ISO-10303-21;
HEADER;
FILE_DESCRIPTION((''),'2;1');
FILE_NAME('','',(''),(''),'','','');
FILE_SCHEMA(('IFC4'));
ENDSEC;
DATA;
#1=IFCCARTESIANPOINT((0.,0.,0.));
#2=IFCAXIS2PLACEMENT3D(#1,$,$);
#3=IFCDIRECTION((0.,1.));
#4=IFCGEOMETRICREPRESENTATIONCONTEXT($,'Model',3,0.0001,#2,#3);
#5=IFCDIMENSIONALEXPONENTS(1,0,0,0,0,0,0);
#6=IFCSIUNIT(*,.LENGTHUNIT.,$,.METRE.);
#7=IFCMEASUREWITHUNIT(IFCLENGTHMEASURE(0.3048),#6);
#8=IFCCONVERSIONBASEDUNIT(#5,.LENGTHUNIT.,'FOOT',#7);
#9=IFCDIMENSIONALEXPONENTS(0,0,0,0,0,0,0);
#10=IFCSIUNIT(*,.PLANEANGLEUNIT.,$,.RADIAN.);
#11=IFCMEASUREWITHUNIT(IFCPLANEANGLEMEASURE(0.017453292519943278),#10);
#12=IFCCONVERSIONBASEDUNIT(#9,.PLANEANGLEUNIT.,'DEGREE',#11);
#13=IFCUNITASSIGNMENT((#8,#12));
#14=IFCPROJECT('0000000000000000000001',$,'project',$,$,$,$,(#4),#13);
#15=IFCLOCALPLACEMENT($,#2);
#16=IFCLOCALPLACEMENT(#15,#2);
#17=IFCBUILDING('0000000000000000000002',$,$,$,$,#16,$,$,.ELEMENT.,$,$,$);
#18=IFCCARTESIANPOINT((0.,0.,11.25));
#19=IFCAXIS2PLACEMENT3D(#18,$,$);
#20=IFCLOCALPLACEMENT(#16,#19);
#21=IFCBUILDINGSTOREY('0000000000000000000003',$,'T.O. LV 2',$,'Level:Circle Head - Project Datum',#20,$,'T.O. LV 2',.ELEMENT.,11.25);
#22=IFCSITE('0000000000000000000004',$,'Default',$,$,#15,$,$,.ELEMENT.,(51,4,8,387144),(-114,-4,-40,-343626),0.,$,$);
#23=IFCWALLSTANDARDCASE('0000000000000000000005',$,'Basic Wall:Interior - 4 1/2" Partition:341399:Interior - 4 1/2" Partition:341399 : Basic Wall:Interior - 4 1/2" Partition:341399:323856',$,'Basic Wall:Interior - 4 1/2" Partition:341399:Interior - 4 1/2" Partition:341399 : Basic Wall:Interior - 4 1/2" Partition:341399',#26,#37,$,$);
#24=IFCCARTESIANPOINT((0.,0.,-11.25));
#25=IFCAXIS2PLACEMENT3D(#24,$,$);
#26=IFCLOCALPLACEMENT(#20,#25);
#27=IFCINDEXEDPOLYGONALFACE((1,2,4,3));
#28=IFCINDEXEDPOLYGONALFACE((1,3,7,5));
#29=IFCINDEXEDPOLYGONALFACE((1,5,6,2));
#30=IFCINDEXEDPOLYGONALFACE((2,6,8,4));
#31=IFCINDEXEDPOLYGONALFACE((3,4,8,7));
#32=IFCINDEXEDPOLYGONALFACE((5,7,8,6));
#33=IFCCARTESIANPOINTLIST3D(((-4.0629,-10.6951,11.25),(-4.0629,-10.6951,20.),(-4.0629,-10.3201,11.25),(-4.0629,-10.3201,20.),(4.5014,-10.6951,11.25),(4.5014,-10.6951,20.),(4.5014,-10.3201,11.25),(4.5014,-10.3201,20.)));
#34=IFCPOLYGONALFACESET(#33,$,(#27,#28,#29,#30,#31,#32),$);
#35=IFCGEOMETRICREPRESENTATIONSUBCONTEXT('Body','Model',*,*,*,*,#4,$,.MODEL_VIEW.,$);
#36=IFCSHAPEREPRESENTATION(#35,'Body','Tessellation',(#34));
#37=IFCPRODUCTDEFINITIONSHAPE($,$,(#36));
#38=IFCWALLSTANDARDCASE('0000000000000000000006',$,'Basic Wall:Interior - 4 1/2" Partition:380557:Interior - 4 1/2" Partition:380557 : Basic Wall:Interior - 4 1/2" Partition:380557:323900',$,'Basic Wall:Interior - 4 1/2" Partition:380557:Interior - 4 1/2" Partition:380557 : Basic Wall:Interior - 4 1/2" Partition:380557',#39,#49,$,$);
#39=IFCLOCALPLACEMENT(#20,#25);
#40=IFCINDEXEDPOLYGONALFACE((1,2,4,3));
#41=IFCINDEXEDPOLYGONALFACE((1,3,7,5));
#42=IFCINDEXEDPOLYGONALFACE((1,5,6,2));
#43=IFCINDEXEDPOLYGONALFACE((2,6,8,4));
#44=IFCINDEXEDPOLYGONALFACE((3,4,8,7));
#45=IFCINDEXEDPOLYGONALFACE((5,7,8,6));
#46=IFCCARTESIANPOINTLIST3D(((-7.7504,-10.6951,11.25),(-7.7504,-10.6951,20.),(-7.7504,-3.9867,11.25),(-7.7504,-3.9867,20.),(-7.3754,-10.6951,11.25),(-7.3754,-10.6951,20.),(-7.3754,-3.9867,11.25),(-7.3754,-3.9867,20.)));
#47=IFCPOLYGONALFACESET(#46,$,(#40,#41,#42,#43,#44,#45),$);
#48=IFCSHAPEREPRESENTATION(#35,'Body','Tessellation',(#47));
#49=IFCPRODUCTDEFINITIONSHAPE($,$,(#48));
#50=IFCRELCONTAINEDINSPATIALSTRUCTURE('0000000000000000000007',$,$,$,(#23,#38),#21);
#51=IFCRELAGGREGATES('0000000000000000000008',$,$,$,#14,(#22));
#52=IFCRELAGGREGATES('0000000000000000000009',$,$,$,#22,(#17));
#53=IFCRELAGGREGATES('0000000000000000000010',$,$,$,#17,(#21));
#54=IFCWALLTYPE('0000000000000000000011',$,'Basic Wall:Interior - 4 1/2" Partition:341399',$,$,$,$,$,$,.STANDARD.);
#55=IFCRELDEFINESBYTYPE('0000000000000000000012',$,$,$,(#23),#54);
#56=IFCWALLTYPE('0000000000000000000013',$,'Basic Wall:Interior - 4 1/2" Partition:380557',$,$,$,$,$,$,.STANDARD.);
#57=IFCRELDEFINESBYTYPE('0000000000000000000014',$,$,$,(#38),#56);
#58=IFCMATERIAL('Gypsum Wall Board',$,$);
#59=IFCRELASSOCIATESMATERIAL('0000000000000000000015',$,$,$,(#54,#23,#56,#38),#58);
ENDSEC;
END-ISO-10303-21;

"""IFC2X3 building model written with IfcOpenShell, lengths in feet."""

from ifc_helpers import new_model, entity, si_unit, converted_unit, direction, frame, origin, origin_2d_with_axis, place, context, subcontext, project, spatial, rectangle, extrude, source, transform, mapped, material, type_object, type_shapes, element, save


model = new_model("IFC2X3")

# Units and contexts
model_context = context("Model", 3, precision=0.0001, world=origin(), true_north=direction((0.0, 1.0)))
body_context = subcontext(model_context, "Body", "Model", "MODEL_VIEW")
ifc_project = project(units=[converted_unit("LENGTHUNIT", "FOOT", entity("IfcLengthMeasure", 0.3048), si_unit("LENGTHUNIT", "METRE"), dimensions=[1, 0, 0, 0, 0, 0, 0]), converted_unit("PLANEANGLEUNIT", "DEGREE", entity("IfcPlaneAngleMeasure", 0.017453292519943278), si_unit("PLANEANGLEUNIT", "RADIAN"), dimensions=[0, 0, 0, 0, 0, 0, 0])], contexts=[model_context])

# Site, building, storey
site_placement = place(None, origin())
site = spatial("IfcSite", under=ifc_project, at=site_placement, Name="Default", CompositionType="ELEMENT", RefLatitude=(51, 4, 8, 387144), RefLongitude=(-114, -4, -40, -343626), RefElevation=0.0)
building_placement = place(site_placement, origin())
building = spatial("IfcBuilding", under=site, at=building_placement, CompositionType="ELEMENT")
storey_placement = place(building_placement, frame((0.0, 0.0, 11.25)))
storey = spatial("IfcBuildingStorey", under=building, at=storey_placement, Name="T.O. LV 2", ObjectType="Level:Circle Head - Project Datum", LongName="T.O. LV 2", CompositionType="ELEMENT", Elevation=11.25)

# Walls
ifc_material_1 = material(Name="Gypsum Wall Board")
wall_type_1 = type_object("IfcWallType", Name="Basic Wall:Interior - 4 1/2\" Partition:341399", PredefinedType="STANDARD", material=ifc_material_1)
shared_shape_1 = source(origin(), body_context, "Body", "SweptSolid", [
    extrude(rectangle(XDim=8.5643, YDim=0.375, at=origin_2d_with_axis()), frame((0.2193, -10.5076, 11.25), z_axis=(0.0, 0.0, 1.0), x_axis=(-1.0, 0.0, 0.0)), (0.0, 0.0, 1.0), 8.75),
])
type_shapes(wall_type_1, [shared_shape_1])
wall_1_placement = place(storey_placement, frame((0.0, 0.0, -11.25)))
element("IfcWallStandardCase", 1, at=wall_1_placement, inside=storey, type_object=wall_type_1, material=ifc_material_1, Name="Basic Wall:Interior - 4 1/2\" Partition:341399:Interior - 4 1/2\" Partition:341399 : Basic Wall:Interior - 4 1/2\" Partition:341399:323856", ObjectType="Basic Wall:Interior - 4 1/2\" Partition:341399:Interior - 4 1/2\" Partition:341399 : Basic Wall:Interior - 4 1/2\" Partition:341399", context=body_context, shape_type="MappedRepresentation", body=[
    mapped(shared_shape_1, transform((0.0, 0.0, 0.0), scale=1.0)),
])
wall_type_2 = type_object("IfcWallType", Name="Basic Wall:Interior - 4 1/2\" Partition:380557", PredefinedType="STANDARD", material=ifc_material_1)
shared_shape_2 = source(origin(), body_context, "Body", "SweptSolid", [
    extrude(rectangle(XDim=6.7083, YDim=0.375, at=origin_2d_with_axis()), frame((-7.5629, -7.3409, 11.25), z_axis=(0.0, 0.0, 1.0), x_axis=(0.0, 1.0, 0.0)), (0.0, 0.0, 1.0), 8.75),
])
type_shapes(wall_type_2, [shared_shape_2])
wall_2_placement = place(storey_placement, frame((0.0, 0.0, -11.25)))
element("IfcWallStandardCase", 2, at=wall_2_placement, inside=storey, type_object=wall_type_2, material=ifc_material_1, Name="Basic Wall:Interior - 4 1/2\" Partition:380557:Interior - 4 1/2\" Partition:380557 : Basic Wall:Interior - 4 1/2\" Partition:380557:323900", ObjectType="Basic Wall:Interior - 4 1/2\" Partition:380557:Interior - 4 1/2\" Partition:380557 : Basic Wall:Interior - 4 1/2\" Partition:380557", context=body_context, shape_type="MappedRepresentation", body=[
    mapped(shared_shape_2, transform((0.0, 0.0, 0.0), scale=1.0)),
])

save(model, "model.ifc")
